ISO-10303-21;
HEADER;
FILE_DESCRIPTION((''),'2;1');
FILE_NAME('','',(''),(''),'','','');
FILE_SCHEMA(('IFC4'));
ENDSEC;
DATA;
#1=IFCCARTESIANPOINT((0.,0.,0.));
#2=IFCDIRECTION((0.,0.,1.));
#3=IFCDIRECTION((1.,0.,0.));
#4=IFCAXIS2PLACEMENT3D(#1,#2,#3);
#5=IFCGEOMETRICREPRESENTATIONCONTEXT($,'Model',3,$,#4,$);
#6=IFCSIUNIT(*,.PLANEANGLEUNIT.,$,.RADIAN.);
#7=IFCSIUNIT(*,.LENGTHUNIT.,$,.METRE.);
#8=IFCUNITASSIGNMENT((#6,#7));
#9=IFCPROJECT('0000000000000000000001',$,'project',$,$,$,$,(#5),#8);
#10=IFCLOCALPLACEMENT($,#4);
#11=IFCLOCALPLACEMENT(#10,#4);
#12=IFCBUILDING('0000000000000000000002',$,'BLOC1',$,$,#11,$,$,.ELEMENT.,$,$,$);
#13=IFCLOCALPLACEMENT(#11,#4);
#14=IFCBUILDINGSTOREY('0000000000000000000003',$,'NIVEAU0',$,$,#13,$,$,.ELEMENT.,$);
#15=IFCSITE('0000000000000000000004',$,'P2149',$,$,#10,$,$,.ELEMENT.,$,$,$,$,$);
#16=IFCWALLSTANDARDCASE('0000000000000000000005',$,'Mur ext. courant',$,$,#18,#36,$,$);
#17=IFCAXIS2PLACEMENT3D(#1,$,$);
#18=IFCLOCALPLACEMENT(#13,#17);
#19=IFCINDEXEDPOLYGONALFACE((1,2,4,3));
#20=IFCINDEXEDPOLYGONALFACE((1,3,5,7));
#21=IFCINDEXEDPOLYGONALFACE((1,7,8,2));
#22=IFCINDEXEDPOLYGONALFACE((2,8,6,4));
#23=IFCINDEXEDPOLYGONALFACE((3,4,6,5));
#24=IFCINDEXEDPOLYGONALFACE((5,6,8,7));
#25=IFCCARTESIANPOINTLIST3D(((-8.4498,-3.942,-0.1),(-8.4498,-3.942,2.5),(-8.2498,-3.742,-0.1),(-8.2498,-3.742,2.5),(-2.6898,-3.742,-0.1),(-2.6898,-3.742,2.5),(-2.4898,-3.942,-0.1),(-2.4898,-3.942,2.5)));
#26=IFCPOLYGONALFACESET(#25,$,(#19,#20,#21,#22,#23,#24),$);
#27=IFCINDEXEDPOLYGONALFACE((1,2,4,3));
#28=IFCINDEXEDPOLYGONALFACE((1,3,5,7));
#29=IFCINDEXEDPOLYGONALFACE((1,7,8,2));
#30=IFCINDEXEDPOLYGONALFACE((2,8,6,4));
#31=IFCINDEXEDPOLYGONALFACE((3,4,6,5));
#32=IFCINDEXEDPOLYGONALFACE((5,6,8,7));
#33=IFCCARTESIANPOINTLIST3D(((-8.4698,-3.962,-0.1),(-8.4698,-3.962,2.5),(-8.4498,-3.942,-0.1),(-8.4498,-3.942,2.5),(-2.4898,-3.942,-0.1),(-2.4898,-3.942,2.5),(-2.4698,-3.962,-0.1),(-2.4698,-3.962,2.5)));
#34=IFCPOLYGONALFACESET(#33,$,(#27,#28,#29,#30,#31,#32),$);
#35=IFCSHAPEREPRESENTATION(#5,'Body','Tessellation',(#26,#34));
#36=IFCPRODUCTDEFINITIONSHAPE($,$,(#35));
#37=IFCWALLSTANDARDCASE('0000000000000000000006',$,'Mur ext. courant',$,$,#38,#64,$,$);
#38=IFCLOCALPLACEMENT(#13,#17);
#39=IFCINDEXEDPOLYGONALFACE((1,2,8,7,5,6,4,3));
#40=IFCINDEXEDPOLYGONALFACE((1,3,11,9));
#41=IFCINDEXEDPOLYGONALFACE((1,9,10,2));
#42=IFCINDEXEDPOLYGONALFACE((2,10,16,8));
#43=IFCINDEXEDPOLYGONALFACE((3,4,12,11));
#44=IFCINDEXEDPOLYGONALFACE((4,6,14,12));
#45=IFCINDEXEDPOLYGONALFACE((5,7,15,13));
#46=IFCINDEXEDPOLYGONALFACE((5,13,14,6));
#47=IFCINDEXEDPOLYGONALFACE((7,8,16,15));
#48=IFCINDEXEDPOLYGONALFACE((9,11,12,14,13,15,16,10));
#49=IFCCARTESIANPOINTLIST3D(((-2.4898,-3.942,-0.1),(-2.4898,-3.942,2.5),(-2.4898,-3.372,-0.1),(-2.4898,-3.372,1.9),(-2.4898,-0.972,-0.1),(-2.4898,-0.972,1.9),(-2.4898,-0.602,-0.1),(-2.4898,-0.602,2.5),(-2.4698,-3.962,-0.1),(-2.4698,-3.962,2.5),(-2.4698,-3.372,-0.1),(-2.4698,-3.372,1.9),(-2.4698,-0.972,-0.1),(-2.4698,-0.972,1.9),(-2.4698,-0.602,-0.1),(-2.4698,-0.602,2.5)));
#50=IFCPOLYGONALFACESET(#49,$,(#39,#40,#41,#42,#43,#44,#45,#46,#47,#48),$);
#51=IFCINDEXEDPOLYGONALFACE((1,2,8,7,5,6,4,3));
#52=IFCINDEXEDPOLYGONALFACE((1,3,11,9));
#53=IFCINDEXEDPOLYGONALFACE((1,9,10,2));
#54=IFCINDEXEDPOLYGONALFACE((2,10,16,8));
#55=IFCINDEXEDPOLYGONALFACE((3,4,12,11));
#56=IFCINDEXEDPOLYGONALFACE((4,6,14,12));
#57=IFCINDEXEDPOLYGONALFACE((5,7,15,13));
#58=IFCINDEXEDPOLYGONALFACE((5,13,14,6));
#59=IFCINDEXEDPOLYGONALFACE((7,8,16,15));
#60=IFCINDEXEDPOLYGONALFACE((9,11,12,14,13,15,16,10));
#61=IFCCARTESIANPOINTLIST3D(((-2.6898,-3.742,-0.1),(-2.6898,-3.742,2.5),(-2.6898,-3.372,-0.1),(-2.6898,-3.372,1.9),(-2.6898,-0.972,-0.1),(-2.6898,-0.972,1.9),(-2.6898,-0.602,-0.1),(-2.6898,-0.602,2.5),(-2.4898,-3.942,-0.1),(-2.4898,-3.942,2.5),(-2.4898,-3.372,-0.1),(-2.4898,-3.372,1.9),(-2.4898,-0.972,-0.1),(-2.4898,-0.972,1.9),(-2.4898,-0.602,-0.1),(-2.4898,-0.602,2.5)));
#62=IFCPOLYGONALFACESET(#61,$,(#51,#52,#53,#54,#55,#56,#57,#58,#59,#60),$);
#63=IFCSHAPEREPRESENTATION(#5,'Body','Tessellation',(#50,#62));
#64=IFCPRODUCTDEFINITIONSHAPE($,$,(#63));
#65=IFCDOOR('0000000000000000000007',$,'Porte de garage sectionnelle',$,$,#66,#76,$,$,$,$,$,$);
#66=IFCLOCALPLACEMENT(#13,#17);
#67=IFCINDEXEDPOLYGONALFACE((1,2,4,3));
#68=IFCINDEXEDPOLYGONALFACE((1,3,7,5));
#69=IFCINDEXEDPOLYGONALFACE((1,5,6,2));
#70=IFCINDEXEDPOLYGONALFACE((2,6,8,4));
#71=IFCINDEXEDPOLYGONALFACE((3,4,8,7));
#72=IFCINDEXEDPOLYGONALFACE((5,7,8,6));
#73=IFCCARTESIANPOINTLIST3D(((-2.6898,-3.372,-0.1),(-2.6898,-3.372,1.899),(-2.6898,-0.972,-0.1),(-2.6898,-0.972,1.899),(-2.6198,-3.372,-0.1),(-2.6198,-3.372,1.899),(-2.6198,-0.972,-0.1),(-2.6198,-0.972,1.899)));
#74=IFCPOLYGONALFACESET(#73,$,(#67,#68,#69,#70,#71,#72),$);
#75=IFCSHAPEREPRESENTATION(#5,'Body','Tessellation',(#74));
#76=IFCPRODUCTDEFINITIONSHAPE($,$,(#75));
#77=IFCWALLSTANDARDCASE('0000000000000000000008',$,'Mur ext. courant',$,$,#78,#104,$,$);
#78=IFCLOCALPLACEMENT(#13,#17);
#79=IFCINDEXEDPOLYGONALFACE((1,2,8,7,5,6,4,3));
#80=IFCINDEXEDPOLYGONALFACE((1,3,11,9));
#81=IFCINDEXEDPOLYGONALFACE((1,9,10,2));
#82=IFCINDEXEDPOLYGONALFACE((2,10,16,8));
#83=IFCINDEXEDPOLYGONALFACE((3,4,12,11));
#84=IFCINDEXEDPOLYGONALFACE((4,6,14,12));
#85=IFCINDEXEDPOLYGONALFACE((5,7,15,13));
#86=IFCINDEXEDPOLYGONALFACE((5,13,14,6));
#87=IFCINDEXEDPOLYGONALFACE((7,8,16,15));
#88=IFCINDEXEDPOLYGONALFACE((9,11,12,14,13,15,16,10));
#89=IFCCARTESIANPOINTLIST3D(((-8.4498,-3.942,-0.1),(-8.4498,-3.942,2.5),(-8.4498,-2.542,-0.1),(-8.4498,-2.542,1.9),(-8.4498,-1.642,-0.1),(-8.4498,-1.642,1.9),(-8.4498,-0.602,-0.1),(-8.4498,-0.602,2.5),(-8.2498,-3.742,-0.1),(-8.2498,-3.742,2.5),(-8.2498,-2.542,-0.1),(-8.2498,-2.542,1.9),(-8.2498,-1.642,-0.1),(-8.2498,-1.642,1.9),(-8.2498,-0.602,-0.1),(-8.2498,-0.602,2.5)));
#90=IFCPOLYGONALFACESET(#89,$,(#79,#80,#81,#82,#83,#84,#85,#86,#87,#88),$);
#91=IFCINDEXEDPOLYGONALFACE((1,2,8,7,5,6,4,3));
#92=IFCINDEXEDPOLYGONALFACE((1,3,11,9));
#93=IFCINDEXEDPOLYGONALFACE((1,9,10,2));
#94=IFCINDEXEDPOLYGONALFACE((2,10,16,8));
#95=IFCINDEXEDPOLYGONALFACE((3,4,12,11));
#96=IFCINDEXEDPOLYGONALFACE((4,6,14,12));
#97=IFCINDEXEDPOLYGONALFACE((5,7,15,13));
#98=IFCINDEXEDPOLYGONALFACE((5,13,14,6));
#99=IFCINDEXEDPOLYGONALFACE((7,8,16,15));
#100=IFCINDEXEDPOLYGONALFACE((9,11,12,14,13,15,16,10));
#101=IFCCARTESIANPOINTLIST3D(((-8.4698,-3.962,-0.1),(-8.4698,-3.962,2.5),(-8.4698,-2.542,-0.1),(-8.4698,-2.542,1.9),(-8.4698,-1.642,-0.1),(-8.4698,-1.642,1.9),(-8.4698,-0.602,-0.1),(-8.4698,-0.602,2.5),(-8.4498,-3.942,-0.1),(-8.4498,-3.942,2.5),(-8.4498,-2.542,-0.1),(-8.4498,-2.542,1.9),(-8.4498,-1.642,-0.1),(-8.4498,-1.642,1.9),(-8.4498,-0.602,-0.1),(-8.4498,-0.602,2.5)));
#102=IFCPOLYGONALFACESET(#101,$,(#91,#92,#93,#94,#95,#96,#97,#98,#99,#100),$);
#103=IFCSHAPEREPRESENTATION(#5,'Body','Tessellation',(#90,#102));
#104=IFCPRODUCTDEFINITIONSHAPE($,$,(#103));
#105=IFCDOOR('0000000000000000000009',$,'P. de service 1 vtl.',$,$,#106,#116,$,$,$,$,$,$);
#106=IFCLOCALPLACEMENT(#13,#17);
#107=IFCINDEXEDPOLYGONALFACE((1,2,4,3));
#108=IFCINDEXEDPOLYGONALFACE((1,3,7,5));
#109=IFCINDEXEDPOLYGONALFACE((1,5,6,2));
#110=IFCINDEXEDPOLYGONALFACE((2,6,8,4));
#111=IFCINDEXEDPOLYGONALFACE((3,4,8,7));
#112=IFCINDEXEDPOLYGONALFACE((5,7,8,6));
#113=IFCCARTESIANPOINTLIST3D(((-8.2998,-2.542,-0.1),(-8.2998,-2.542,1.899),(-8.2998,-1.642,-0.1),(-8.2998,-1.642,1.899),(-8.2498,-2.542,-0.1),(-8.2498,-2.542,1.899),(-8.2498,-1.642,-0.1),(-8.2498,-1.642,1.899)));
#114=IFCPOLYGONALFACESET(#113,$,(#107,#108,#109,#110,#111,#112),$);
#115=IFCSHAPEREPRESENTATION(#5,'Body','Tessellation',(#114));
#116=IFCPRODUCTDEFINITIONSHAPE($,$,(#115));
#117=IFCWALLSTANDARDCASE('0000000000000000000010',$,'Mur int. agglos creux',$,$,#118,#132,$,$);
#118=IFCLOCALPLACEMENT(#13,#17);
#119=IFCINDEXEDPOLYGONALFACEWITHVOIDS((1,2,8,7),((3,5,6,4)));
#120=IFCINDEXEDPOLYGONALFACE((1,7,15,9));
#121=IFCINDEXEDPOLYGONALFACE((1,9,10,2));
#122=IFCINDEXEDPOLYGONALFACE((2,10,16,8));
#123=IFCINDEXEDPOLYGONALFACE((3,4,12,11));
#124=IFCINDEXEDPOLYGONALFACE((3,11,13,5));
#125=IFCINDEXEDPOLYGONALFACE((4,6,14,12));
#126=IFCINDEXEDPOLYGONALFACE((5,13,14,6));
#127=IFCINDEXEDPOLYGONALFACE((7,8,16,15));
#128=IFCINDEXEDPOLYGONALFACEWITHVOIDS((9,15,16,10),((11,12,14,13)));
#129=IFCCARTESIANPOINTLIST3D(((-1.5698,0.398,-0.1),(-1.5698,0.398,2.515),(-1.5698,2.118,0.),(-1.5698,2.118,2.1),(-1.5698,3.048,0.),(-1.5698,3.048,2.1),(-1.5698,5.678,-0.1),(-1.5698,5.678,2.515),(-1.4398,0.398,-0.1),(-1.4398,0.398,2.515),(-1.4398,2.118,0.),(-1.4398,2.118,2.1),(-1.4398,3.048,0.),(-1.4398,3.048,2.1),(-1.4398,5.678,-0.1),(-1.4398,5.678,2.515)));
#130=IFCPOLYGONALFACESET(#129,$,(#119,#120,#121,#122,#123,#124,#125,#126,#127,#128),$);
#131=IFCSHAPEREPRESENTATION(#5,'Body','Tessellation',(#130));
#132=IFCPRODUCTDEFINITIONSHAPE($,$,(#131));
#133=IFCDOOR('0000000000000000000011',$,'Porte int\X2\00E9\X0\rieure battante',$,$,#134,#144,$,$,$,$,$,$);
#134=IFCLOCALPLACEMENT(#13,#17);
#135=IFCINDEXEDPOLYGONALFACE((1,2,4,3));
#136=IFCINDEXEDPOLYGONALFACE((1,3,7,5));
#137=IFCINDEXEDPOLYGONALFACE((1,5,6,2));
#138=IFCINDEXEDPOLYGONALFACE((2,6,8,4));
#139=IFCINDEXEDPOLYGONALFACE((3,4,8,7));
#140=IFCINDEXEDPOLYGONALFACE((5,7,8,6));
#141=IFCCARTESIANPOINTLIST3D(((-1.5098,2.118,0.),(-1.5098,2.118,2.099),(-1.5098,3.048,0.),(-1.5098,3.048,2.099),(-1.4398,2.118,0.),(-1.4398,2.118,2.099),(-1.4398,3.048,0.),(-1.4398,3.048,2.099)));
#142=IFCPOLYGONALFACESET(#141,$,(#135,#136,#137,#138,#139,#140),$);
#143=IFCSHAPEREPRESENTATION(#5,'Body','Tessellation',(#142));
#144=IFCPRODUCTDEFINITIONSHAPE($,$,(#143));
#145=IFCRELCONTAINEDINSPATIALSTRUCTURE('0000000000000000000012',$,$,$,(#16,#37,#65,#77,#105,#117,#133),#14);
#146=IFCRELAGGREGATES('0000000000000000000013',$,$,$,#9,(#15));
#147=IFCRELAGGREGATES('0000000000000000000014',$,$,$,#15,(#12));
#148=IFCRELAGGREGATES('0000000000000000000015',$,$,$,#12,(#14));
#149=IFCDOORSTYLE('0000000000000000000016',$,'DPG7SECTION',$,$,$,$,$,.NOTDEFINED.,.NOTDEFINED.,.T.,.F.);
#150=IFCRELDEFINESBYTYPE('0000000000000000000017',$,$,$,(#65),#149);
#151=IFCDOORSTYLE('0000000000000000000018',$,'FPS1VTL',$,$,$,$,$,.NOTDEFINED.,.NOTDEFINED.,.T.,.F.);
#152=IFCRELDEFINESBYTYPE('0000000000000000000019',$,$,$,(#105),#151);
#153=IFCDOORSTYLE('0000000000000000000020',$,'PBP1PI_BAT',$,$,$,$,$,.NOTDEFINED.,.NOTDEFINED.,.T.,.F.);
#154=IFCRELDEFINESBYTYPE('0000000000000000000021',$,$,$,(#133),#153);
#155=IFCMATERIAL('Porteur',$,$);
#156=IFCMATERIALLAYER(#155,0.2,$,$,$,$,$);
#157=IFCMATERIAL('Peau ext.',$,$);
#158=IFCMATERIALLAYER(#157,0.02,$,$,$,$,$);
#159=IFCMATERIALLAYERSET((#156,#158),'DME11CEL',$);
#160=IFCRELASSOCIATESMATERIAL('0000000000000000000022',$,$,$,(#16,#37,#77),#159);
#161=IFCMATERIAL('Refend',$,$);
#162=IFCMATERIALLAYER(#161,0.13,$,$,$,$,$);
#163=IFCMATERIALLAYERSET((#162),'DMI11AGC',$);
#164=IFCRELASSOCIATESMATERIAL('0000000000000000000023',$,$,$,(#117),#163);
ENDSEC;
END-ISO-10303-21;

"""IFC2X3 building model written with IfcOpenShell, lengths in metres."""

from ifc_helpers import new_model, si_unit, point, frame, frame_2d, origin_with_axes, place, context, project, spatial, line_curve, trimmed, segment, composite_curve, rectangle, outline, extrude, material, layer, layer_set, layer_usage, type_object, element, fill, save


model = new_model("IFC2X3")

# Units and contexts
model_context = context("Model", 3, world=origin_with_axes())
ifc_project = project(units=[si_unit("PLANEANGLEUNIT", "RADIAN"), si_unit("LENGTHUNIT", "METRE")], contexts=[model_context])

# Site, building, storey
site_placement = place(None, origin_with_axes())
site = spatial("IfcSite", under=ifc_project, at=site_placement, Name="P2149", CompositionType="ELEMENT")
building_placement = place(site_placement, origin_with_axes())
building = spatial("IfcBuilding", under=site, at=building_placement, Name="BLOC1", CompositionType="ELEMENT")
storey_placement = place(building_placement, origin_with_axes())
storey = spatial("IfcBuildingStorey", under=building, at=storey_placement, Name="NIVEAU0", CompositionType="ELEMENT")

# Wall
ifc_material_1 = material(Name="Porteur")
ifc_layer_1 = layer(ifc_material_1, 0.2)
ifc_material_2 = material(Name="Peau ext.")
ifc_layer_2 = layer(ifc_material_2, 0.02)
ifc_layer_set_1 = layer_set([ifc_layer_1, ifc_layer_2], Name="DME11CEL")
ifc_layer_usage_1 = layer_usage(ifc_layer_set_1, "AXIS2", "POSITIVE", 0.0)
wall_1_placement = place(storey_placement, frame((-2.6898, -3.742, -0.1), z_axis=(0.0, 0.0, 1.0), x_axis=(-1.0, 0.0, 0.0)))
element("IfcWallStandardCase", 1, at=wall_1_placement, inside=storey, material=ifc_layer_usage_1, Name="Mur ext. courant", context=model_context, shape_type="SweptSolid", body=[
    extrude(outline(composite_curve([segment(trimmed(line_curve((0.0, 0.0), (1.0, 0.0), 5.56), [point((0.0, 0.0))], [point((5.56, 0.0))], True, "CARTESIAN"), True, "CONTINUOUS"), segment(trimmed(line_curve((5.56, 0.0), (0.707107, 0.707107), 0.282843), [point((5.56, 0.0))], [point((5.76, 0.2))], True, "CARTESIAN"), True, "CONTINUOUS"), segment(trimmed(line_curve((5.76, 0.2), (-1.0, 0.0), 5.96), [point((5.76, 0.2))], [point((-0.2, 0.2))], True, "CARTESIAN"), True, "CONTINUOUS"), segment(trimmed(line_curve((-0.2, 0.2), (0.707107, -0.707107), 0.282843), [point((-0.2, 0.2))], [point((0.0, 0.0))], True, "CARTESIAN"), True, "CONTINUOUS")], self_intersect=False)), origin_with_axes(), (0.0, 0.0, 1.0), 2.6),
    extrude(outline(composite_curve([segment(trimmed(line_curve((-0.2, 0.2), (1.0, 0.0), 5.96), [point((-0.2, 0.2))], [point((5.76, 0.2))], True, "CARTESIAN"), True, "CONTINUOUS"), segment(trimmed(line_curve((5.76, 0.2), (0.707107, 0.707107), 0.028284), [point((5.76, 0.2))], [point((5.78, 0.22))], True, "CARTESIAN"), True, "CONTINUOUS"), segment(trimmed(line_curve((5.78, 0.22), (-1.0, 0.0), 6.0), [point((5.78, 0.22))], [point((-0.22, 0.22))], True, "CARTESIAN"), True, "CONTINUOUS"), segment(trimmed(line_curve((-0.22, 0.22), (0.707107, -0.707107), 0.028284), [point((-0.22, 0.22))], [point((-0.2, 0.2))], True, "CARTESIAN"), True, "CONTINUOUS")], self_intersect=False)), origin_with_axes(), (0.0, 0.0, 1.0), 2.6),
])

# Walls, openings, doors
wall_2_placement = place(storey_placement, frame((-2.6898, -0.602, -0.1), z_axis=(0.0, 0.0, 1.0), x_axis=(0.0, -1.0, 0.0)))
wall_2 = element("IfcWallStandardCase", 2, at=wall_2_placement, inside=storey, material=ifc_layer_usage_1, Name="Mur ext. courant", context=model_context, shape_type="SweptSolid", body=[
    extrude(outline(composite_curve([segment(trimmed(line_curve((0.0, 0.2), (1.0, 0.0), 3.34), [point((0.0, 0.2))], [point((3.34, 0.2))], True, "CARTESIAN"), True, "CONTINUOUS"), segment(trimmed(line_curve((3.34, 0.2), (0.707107, 0.707107), 0.028284), [point((3.34, 0.2))], [point((3.36, 0.22))], True, "CARTESIAN"), True, "CONTINUOUS"), segment(trimmed(line_curve((3.36, 0.22), (-1.0, 0.0), 3.36), [point((3.36, 0.22))], [point((0.0, 0.22))], True, "CARTESIAN"), True, "CONTINUOUS"), segment(trimmed(line_curve((0.0, 0.22), (0.0, -1.0), 0.02), [point((0.0, 0.22))], [point((0.0, 0.2))], True, "CARTESIAN"), True, "CONTINUOUS")], self_intersect=False)), origin_with_axes(), (0.0, 0.0, 1.0), 2.6),
    extrude(outline(composite_curve([segment(trimmed(line_curve((0.0, 0.0), (1.0, 0.0), 3.14), [point((0.0, 0.0))], [point((3.14, 0.0))], True, "CARTESIAN"), True, "CONTINUOUS"), segment(trimmed(line_curve((3.14, 0.0), (0.707107, 0.707107), 0.282843), [point((3.14, 0.0))], [point((3.34, 0.2))], True, "CARTESIAN"), True, "CONTINUOUS"), segment(trimmed(line_curve((3.34, 0.2), (-1.0, 0.0), 3.34), [point((3.34, 0.2))], [point((0.0, 0.2))], True, "CARTESIAN"), True, "CONTINUOUS"), segment(trimmed(line_curve((0.0, 0.2), (0.0, -1.0), 0.2), [point((0.0, 0.2))], [point((0.0, 0.0))], True, "CARTESIAN"), True, "CONTINUOUS")], self_intersect=False)), origin_with_axes(), (0.0, 0.0, 1.0), 2.6),
])
opening_1_placement = place(wall_2_placement, frame((0.37, 0.0, 0.0), z_axis=(0.0, -1.0, 0.0), x_axis=(1.0, 0.0, 0.0)))
opening_1 = element("IfcOpeningElement", 3, at=opening_1_placement, cuts=wall_2, context=model_context, shape_type="SweptSolid", body=[
    extrude(rectangle(XDim=2.4, YDim=2.0, at=frame_2d((1.2, 1.0), x_axis=(1.0, 0.0))), origin_with_axes(), (0.0, 0.0, -1.0), 0.22),
])
door_style_1 = type_object("IfcDoorStyle", Name="DPG7SECTION", ConstructionType="NOTDEFINED", OperationType="NOTDEFINED", ParameterTakesPrecedence=True, Sizeable=False)
door_1_placement = place(opening_1_placement, origin_with_axes())
door_1 = element("IfcDoor", 4, at=door_1_placement, inside=storey, type_object=door_style_1, Name="Porte de garage sectionnelle", context=model_context, shape_type="SweptSolid", body=[
    extrude(rectangle(XDim=2.4, YDim=1.999, at=frame_2d((1.2, 0.9995), x_axis=(1.0, 0.0))), origin_with_axes(), (0.0, 0.0, -1.0), 0.07),
])
fill(opening_1, door_1)
wall_3_placement = place(storey_placement, frame((-8.2498, -3.742, -0.1), z_axis=(0.0, 0.0, 1.0), x_axis=(0.0, 1.0, 0.0)))
wall_3 = element("IfcWallStandardCase", 5, at=wall_3_placement, inside=storey, material=ifc_layer_usage_1, Name="Mur ext. courant", context=model_context, shape_type="SweptSolid", body=[
    extrude(outline(composite_curve([segment(trimmed(line_curve((0.0, 0.0), (1.0, 0.0), 3.14), [point((0.0, 0.0))], [point((3.14, 0.0))], True, "CARTESIAN"), True, "CONTINUOUS"), segment(trimmed(line_curve((3.14, 0.0), (0.0, 1.0), 0.2), [point((3.14, 0.0))], [point((3.14, 0.2))], True, "CARTESIAN"), True, "CONTINUOUS"), segment(trimmed(line_curve((3.14, 0.2), (-1.0, 0.0), 3.34), [point((3.14, 0.2))], [point((-0.2, 0.2))], True, "CARTESIAN"), True, "CONTINUOUS"), segment(trimmed(line_curve((-0.2, 0.2), (0.707107, -0.707107), 0.282843), [point((-0.2, 0.2))], [point((0.0, 0.0))], True, "CARTESIAN"), True, "CONTINUOUS")], self_intersect=False)), origin_with_axes(), (0.0, 0.0, 1.0), 2.6),
    extrude(outline(composite_curve([segment(trimmed(line_curve((-0.2, 0.2), (1.0, 0.0), 3.34), [point((-0.2, 0.2))], [point((3.14, 0.2))], True, "CARTESIAN"), True, "CONTINUOUS"), segment(trimmed(line_curve((3.14, 0.2), (0.0, 1.0), 0.02), [point((3.14, 0.2))], [point((3.14, 0.22))], True, "CARTESIAN"), True, "CONTINUOUS"), segment(trimmed(line_curve((3.14, 0.22), (-1.0, 0.0), 3.36), [point((3.14, 0.22))], [point((-0.22, 0.22))], True, "CARTESIAN"), True, "CONTINUOUS"), segment(trimmed(line_curve((-0.22, 0.22), (0.707107, -0.707107), 0.028284), [point((-0.22, 0.22))], [point((-0.2, 0.2))], True, "CARTESIAN"), True, "CONTINUOUS")], self_intersect=False)), origin_with_axes(), (0.0, 0.0, 1.0), 2.6),
])
opening_2_placement = place(wall_3_placement, frame((1.2, 0.0, 0.0), z_axis=(0.0, -1.0, 0.0), x_axis=(1.0, 0.0, 0.0)))
opening_2 = element("IfcOpeningElement", 6, at=opening_2_placement, cuts=wall_3, context=model_context, shape_type="SweptSolid", body=[
    extrude(rectangle(XDim=0.9, YDim=2.0, at=frame_2d((0.45, 1.0), x_axis=(1.0, 0.0))), origin_with_axes(), (0.0, 0.0, -1.0), 0.22),
])
door_style_2 = type_object("IfcDoorStyle", Name="FPS1VTL", ConstructionType="NOTDEFINED", OperationType="NOTDEFINED", ParameterTakesPrecedence=True, Sizeable=False)
door_2_placement = place(opening_2_placement, origin_with_axes())
door_2 = element("IfcDoor", 7, at=door_2_placement, inside=storey, type_object=door_style_2, Name="P. de service 1 vtl.", context=model_context, shape_type="SweptSolid", body=[
    extrude(rectangle(XDim=0.9, YDim=1.999, at=frame_2d((0.45, 0.9995), x_axis=(1.0, 0.0))), origin_with_axes(), (0.0, 0.0, -1.0), 0.05),
])
fill(opening_2, door_2)
ifc_material_3 = material(Name="Refend")
ifc_layer_3 = layer(ifc_material_3, 0.13)
ifc_layer_set_2 = layer_set([ifc_layer_3], Name="DMI11AGC")
ifc_layer_usage_2 = layer_usage(ifc_layer_set_2, "AXIS2", "POSITIVE", 0.0)
wall_4_placement = place(storey_placement, frame((-1.4398, 0.398, -0.1), z_axis=(0.0, 0.0, 1.0), x_axis=(0.0, 1.0, 0.0)))
wall_4 = element("IfcWallStandardCase", 8, at=wall_4_placement, inside=storey, material=ifc_layer_usage_2, Name="Mur int. agglos creux", context=model_context, shape_type="SweptSolid", body=[
    extrude(outline(composite_curve([segment(trimmed(line_curve((0.0, 0.0), (1.0, 0.0), 5.28), [point((0.0, 0.0))], [point((5.28, 0.0))], True, "CARTESIAN"), True, "CONTINUOUS"), segment(trimmed(line_curve((5.28, 0.0), (0.0, 1.0), 0.13), [point((5.28, 0.0))], [point((5.28, 0.13))], True, "CARTESIAN"), True, "CONTINUOUS"), segment(trimmed(line_curve((5.28, 0.13), (-1.0, 0.0), 5.28), [point((5.28, 0.13))], [point((0.0, 0.13))], True, "CARTESIAN"), True, "CONTINUOUS"), segment(trimmed(line_curve((0.0, 0.13), (0.0, -1.0), 0.13), [point((0.0, 0.13))], [point((0.0, 0.0))], True, "CARTESIAN"), True, "CONTINUOUS")], self_intersect=False)), origin_with_axes(), (0.0, 0.0, 1.0), 2.615),
])
opening_3_placement = place(wall_4_placement, frame((1.72, 0.0, 0.1), z_axis=(0.0, -1.0, 0.0), x_axis=(1.0, 0.0, 0.0)))
opening_3 = element("IfcOpeningElement", 9, at=opening_3_placement, cuts=wall_4, context=model_context, shape_type="SweptSolid", body=[
    extrude(rectangle(XDim=0.93, YDim=2.1, at=frame_2d((0.465, 1.05), x_axis=(1.0, 0.0))), origin_with_axes(), (0.0, 0.0, -1.0), 0.13),
])
door_style_3 = type_object("IfcDoorStyle", Name="PBP1PI_BAT", ConstructionType="NOTDEFINED", OperationType="NOTDEFINED", ParameterTakesPrecedence=True, Sizeable=False)
door_3_placement = place(opening_3_placement, origin_with_axes())
door_3 = element("IfcDoor", 10, at=door_3_placement, inside=storey, type_object=door_style_3, Name="Porte intérieure battante", context=model_context, shape_type="SweptSolid", body=[
    extrude(rectangle(XDim=0.93, YDim=2.099, at=frame_2d((0.465, 1.0495), x_axis=(1.0, 0.0))), origin_with_axes(), (0.0, 0.0, -1.0), 0.07),
])
fill(opening_3, door_3)

save(model, "model.ifc")
